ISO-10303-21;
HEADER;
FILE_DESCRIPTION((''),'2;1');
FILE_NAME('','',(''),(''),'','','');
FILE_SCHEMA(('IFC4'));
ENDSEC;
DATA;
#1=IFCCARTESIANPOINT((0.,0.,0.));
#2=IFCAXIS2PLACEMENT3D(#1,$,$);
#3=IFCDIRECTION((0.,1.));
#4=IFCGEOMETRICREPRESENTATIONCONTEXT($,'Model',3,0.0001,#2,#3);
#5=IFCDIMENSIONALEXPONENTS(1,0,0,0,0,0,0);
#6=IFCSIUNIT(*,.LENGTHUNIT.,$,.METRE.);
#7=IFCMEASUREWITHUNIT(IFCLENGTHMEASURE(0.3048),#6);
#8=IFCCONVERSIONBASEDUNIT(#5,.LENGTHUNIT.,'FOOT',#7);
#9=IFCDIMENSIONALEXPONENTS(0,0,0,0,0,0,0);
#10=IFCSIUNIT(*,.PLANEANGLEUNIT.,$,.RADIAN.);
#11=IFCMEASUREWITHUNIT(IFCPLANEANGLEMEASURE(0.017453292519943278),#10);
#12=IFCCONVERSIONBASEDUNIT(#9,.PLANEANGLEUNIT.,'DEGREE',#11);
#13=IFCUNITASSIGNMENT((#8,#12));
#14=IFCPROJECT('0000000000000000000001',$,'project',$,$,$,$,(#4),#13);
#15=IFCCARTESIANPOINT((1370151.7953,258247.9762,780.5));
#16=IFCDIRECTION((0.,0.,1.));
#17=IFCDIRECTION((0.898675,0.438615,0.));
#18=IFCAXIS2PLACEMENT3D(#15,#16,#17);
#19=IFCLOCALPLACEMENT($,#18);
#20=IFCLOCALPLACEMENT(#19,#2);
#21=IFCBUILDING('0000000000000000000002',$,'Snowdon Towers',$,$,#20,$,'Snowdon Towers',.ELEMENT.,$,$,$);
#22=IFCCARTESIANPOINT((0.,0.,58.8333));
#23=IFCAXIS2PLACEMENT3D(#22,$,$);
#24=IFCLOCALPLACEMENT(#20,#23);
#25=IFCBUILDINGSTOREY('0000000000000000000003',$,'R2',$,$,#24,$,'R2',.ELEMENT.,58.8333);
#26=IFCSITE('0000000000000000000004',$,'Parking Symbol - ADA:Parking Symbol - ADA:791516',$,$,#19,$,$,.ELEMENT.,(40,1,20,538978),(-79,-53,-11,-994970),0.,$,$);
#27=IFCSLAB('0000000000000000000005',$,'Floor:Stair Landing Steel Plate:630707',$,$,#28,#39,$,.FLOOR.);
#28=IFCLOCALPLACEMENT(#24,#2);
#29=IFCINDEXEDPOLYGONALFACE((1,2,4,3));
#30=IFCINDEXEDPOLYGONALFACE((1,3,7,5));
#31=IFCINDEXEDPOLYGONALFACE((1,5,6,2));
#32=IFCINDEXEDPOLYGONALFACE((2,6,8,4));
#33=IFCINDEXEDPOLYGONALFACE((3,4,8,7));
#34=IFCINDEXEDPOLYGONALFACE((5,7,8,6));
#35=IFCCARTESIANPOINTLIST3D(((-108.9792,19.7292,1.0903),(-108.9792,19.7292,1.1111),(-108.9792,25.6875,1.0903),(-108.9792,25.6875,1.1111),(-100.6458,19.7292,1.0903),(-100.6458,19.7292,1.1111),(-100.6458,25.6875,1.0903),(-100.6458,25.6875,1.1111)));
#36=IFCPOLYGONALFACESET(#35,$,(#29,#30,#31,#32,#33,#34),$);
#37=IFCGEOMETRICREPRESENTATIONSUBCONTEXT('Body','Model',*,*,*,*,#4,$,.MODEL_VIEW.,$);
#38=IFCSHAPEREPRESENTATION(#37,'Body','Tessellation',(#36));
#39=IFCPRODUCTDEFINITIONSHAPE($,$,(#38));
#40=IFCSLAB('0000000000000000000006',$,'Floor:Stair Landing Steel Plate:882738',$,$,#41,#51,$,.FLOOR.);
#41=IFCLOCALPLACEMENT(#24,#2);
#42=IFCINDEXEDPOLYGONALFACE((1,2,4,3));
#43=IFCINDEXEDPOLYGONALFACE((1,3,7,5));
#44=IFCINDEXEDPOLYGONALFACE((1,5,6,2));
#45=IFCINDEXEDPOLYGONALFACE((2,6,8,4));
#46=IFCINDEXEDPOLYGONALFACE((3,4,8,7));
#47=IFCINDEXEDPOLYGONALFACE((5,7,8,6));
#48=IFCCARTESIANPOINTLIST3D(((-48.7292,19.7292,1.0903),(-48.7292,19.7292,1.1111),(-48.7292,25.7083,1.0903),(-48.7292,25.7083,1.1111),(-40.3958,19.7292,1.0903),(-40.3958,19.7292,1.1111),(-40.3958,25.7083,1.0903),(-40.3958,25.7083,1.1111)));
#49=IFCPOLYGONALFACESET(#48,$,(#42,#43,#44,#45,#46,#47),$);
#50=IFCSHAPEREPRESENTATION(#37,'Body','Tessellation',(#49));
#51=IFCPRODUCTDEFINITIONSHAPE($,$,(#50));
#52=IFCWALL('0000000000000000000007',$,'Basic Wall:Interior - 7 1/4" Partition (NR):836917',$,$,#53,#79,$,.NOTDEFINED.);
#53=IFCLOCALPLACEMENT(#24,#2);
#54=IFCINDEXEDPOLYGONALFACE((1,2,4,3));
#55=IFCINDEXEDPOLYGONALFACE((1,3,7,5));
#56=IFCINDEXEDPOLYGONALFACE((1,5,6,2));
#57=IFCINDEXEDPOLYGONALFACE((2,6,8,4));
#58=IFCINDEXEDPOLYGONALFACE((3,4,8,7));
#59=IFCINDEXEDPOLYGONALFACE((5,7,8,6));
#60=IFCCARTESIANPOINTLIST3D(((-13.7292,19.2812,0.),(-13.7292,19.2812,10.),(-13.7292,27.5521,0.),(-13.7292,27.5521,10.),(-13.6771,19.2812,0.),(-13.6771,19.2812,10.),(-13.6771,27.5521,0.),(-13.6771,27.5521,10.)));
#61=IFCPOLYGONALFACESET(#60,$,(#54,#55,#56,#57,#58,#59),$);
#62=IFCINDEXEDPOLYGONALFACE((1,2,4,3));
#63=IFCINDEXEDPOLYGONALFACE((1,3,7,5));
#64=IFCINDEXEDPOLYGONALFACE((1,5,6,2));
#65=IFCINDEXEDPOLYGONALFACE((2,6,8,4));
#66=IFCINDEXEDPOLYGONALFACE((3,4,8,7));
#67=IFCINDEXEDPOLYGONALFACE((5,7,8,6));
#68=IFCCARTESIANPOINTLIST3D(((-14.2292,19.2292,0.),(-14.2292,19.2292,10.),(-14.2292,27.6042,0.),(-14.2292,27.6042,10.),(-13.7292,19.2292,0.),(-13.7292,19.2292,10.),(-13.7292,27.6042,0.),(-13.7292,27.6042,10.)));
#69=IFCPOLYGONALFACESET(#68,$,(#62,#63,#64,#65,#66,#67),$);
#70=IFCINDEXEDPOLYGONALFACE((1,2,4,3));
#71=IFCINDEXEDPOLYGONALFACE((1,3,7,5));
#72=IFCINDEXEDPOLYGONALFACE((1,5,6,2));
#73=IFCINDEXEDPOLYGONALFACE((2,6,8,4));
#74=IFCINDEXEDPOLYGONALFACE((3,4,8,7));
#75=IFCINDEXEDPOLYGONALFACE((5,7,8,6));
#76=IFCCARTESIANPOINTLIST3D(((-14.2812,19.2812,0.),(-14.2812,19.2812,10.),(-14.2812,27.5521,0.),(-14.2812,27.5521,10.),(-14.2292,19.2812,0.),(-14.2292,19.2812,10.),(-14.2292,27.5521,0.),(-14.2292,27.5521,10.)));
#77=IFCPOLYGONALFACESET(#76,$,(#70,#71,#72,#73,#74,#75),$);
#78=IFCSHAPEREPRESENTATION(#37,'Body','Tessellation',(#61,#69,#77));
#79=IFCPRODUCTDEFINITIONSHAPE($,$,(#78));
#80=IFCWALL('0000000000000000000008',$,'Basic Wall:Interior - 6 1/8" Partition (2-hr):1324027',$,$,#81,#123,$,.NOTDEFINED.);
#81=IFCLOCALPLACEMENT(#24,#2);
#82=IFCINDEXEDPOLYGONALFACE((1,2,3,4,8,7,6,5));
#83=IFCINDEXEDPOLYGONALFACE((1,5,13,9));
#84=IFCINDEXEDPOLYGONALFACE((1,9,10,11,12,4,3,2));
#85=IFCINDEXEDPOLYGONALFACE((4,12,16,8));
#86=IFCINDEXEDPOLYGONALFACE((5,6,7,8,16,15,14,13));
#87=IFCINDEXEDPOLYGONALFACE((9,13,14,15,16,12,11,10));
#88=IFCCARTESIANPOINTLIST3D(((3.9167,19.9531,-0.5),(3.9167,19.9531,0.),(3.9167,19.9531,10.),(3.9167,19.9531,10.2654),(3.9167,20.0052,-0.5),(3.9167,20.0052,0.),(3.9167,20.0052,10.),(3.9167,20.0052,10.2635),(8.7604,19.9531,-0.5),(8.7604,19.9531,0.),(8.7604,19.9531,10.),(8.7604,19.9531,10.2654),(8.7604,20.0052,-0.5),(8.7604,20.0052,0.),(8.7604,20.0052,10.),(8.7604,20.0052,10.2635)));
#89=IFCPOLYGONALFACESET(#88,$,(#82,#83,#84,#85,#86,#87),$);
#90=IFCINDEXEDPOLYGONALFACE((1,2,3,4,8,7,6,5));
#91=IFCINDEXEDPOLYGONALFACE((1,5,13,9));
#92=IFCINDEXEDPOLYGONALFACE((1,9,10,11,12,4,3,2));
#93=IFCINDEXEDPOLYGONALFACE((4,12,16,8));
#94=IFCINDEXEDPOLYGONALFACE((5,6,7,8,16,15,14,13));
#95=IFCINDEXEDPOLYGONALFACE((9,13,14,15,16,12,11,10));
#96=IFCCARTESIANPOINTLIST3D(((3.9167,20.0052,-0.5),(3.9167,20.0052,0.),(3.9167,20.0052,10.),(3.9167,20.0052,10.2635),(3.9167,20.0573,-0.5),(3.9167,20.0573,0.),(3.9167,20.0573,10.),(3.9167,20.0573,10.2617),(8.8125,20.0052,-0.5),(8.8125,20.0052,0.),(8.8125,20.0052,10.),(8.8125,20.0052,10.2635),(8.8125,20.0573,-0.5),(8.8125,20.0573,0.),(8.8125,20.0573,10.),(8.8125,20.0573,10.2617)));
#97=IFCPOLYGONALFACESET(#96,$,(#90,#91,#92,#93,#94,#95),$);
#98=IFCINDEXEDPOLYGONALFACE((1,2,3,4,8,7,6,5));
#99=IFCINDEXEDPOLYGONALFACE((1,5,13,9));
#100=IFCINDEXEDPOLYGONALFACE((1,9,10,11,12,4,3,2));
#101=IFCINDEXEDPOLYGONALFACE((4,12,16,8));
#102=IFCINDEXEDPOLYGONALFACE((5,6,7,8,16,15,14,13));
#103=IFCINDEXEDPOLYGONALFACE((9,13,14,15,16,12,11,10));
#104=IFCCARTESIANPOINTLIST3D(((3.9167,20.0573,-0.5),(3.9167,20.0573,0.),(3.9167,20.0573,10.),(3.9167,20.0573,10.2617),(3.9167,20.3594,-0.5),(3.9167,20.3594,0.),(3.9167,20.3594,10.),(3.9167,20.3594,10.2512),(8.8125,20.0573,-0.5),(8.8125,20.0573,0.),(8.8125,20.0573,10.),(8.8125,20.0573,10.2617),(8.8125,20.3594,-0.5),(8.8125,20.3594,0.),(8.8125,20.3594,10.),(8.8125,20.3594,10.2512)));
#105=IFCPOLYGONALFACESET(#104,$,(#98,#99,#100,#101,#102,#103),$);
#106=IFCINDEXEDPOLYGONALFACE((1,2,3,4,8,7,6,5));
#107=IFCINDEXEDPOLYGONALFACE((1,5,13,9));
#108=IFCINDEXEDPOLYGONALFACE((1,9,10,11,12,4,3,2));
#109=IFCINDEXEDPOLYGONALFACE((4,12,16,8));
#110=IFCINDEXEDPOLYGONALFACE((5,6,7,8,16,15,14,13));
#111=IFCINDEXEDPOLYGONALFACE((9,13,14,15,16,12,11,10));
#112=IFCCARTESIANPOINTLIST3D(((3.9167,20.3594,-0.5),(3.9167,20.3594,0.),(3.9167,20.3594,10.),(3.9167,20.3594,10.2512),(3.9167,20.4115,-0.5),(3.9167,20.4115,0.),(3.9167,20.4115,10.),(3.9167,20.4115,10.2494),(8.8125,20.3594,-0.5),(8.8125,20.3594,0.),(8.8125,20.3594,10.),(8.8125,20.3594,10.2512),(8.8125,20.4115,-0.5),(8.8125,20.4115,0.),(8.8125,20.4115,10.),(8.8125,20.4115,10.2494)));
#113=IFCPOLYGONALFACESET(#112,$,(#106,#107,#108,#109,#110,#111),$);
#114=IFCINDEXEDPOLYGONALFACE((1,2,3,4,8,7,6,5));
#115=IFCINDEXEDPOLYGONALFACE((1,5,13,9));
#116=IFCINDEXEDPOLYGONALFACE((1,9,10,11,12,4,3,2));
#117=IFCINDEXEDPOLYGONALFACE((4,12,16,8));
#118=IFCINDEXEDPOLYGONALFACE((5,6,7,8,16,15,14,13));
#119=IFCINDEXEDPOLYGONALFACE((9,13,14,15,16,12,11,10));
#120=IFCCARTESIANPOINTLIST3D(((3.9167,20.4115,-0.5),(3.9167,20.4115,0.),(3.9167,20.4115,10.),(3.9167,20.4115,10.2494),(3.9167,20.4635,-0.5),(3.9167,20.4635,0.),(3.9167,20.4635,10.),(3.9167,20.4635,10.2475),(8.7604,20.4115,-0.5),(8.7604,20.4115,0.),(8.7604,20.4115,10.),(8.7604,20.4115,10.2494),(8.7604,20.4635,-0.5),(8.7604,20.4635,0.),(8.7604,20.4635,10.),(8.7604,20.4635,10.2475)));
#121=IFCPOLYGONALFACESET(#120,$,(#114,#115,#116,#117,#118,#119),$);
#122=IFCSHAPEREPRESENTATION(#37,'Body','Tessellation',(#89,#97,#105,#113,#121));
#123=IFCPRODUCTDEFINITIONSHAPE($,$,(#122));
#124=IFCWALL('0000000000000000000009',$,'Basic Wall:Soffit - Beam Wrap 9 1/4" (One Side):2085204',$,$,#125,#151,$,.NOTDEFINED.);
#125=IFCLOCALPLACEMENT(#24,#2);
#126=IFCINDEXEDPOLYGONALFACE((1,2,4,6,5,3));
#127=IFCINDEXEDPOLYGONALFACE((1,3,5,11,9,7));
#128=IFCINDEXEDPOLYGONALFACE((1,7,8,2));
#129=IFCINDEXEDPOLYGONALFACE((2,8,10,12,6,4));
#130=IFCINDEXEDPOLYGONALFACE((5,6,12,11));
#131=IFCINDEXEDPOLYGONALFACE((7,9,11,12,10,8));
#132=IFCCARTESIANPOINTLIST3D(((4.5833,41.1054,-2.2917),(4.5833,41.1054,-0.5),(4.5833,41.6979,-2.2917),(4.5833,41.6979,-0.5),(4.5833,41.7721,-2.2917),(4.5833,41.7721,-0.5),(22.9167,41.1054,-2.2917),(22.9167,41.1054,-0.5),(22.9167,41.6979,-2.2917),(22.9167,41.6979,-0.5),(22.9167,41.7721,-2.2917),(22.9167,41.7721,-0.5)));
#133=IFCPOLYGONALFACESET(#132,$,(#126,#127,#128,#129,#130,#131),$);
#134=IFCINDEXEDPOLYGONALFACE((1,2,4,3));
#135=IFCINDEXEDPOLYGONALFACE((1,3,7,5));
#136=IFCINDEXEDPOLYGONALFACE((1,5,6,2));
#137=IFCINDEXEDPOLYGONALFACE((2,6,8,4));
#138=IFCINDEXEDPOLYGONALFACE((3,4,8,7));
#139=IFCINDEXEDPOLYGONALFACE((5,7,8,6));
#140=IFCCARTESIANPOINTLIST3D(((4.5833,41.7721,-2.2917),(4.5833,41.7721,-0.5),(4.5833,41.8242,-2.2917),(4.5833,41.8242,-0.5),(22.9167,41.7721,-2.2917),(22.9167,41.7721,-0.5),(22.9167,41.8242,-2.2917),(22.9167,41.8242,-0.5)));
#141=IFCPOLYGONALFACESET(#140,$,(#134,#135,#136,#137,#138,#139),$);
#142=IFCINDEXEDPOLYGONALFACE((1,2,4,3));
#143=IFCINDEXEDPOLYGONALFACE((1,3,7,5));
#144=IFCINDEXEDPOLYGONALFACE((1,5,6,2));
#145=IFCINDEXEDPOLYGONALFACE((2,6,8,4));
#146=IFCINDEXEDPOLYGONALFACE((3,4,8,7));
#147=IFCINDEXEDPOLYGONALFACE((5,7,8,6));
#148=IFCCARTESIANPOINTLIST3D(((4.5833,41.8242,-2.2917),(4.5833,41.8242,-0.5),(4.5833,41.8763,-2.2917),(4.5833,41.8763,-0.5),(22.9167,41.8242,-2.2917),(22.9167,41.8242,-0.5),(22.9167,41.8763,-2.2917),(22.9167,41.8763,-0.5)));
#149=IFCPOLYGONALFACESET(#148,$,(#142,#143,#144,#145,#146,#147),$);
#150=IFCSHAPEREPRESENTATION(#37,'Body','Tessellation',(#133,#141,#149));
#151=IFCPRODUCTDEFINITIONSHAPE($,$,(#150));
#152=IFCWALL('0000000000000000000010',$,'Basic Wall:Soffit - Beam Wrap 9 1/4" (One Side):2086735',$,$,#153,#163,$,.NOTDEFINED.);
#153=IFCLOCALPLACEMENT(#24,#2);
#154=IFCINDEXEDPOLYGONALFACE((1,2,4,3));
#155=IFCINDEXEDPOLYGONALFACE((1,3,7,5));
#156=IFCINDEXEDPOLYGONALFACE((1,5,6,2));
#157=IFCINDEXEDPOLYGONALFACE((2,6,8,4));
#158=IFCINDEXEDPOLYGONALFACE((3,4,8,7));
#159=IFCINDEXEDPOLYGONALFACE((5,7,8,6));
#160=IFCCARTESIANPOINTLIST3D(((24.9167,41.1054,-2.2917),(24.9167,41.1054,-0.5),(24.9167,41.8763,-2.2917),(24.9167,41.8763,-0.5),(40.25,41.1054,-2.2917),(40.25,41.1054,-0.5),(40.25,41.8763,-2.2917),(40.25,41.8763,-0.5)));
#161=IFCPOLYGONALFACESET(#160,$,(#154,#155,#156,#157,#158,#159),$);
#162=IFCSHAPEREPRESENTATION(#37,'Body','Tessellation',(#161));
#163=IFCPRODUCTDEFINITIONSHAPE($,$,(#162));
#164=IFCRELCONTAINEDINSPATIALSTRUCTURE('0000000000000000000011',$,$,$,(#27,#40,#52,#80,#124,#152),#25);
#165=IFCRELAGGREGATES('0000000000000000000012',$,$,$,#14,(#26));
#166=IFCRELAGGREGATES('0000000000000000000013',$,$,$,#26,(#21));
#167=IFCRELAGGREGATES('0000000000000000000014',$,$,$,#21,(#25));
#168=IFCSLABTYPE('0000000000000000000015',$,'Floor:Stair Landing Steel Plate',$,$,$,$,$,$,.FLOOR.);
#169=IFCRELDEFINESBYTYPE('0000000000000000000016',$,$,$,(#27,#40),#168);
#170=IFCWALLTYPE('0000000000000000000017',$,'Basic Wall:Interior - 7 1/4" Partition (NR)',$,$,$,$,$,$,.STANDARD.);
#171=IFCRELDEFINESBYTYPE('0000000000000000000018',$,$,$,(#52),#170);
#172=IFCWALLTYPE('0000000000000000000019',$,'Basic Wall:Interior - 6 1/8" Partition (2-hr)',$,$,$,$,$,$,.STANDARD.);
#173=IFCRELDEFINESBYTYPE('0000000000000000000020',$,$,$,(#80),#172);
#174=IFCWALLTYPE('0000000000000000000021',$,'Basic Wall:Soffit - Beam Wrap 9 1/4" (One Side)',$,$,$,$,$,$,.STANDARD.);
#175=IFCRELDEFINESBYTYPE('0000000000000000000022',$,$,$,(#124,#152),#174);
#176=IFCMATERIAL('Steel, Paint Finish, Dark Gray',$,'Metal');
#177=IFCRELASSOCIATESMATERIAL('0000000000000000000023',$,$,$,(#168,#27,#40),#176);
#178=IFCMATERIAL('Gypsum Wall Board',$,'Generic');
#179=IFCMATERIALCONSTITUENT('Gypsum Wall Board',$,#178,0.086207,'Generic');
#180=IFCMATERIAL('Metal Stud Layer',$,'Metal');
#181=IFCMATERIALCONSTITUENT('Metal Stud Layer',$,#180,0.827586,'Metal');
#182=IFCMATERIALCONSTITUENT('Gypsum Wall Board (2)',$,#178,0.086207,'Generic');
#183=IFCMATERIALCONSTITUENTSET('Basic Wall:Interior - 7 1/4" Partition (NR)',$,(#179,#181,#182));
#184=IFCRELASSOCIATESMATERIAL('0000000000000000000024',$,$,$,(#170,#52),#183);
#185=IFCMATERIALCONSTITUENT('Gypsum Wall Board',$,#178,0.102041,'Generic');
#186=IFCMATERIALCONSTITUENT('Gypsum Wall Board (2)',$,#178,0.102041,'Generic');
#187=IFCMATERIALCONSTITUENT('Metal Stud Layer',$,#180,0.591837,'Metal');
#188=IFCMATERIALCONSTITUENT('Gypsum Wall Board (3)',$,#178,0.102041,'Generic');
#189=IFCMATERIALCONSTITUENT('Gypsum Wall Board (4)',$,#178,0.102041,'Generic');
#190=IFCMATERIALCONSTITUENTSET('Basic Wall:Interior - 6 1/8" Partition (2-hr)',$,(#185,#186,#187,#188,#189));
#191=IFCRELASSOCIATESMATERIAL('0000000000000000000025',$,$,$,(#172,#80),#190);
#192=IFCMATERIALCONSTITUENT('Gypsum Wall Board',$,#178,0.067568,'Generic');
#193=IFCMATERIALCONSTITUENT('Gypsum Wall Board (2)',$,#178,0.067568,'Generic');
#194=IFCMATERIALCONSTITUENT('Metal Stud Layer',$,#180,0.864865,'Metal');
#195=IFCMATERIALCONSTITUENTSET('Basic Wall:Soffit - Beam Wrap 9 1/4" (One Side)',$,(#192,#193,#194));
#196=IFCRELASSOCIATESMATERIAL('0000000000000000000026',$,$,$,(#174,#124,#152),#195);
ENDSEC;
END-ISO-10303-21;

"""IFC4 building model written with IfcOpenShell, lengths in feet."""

from ifc_helpers import new_model, entity, si_unit, converted_unit, direction, frame, origin, place, context, subcontext, project, spatial, indexed_curve, outline, extrude, material, constituent, constituent_set, type_object, element, save


model = new_model("IFC4")

# Units and contexts
model_context = context("Model", 3, precision=0.0001, world=origin(), true_north=direction((0.0, 1.0)))
body_context = subcontext(model_context, "Body", "Model", "MODEL_VIEW")
ifc_project = project(units=[converted_unit("LENGTHUNIT", "FOOT", entity("IfcLengthMeasure", 0.3048), si_unit("LENGTHUNIT", "METRE"), dimensions=[1, 0, 0, 0, 0, 0, 0]), converted_unit("PLANEANGLEUNIT", "DEGREE", entity("IfcPlaneAngleMeasure", 0.017453292519943278), si_unit("PLANEANGLEUNIT", "RADIAN"), dimensions=[0, 0, 0, 0, 0, 0, 0])], contexts=[model_context])

# Site, building, storey
site_placement = place(None, frame((1370151.7953, 258247.9762, 780.5), z_axis=(0.0, 0.0, 1.0), x_axis=(0.898675, 0.438615, 0.0)))
site = spatial("IfcSite", under=ifc_project, at=site_placement, Name="Parking Symbol - ADA:Parking Symbol - ADA:791516", CompositionType="ELEMENT", RefLatitude=(40, 1, 20, 538978), RefLongitude=(-79, -53, -11, -994970), RefElevation=0.0)
building_placement = place(site_placement, origin())
building = spatial("IfcBuilding", under=site, at=building_placement, Name="Snowdon Towers", LongName="Snowdon Towers", CompositionType="ELEMENT")
storey_placement = place(building_placement, frame((0.0, 0.0, 58.8333)))
storey = spatial("IfcBuildingStorey", under=building, at=storey_placement, Name="R2", LongName="R2", CompositionType="ELEMENT", Elevation=58.8333)

# Slabs
ifc_material_1 = material(Name="Steel, Paint Finish, Dark Gray", Category="Metal")
slab_type_1 = type_object("IfcSlabType", Name="Floor:Stair Landing Steel Plate", PredefinedType="FLOOR", material=ifc_material_1)
slab_1_placement = place(storey_placement, origin())
element("IfcSlab", 1, at=slab_1_placement, inside=storey, type_object=slab_type_1, material=ifc_material_1, Name="Floor:Stair Landing Steel Plate:630707", PredefinedType="FLOOR", context=body_context, shape_type="SweptSolid", body=[
    extrude(outline(indexed_curve([(-2.9792, -4.1667), (2.9792, -4.1667), (2.9792, 4.1667), (-2.9792, 4.1667), (-2.9792, -4.1667)], self_intersect=False)), frame((-104.8125, 22.7083, 1.1111), z_axis=(0.0, 0.0, -1.0), x_axis=(0.0, 1.0, 0.0)), (0.0, 0.0, 1.0), 0.0208),
])
slab_2_placement = place(storey_placement, origin())
element("IfcSlab", 2, at=slab_2_placement, inside=storey, type_object=slab_type_1, material=ifc_material_1, Name="Floor:Stair Landing Steel Plate:882738", PredefinedType="FLOOR", context=body_context, shape_type="SweptSolid", body=[
    extrude(outline(indexed_curve([(-2.9896, -4.1667), (2.9896, -4.1667), (2.9896, 4.1667), (-2.9896, 4.1667), (-2.9896, -4.1667)], self_intersect=False)), frame((-44.5625, 22.7188, 1.1111), z_axis=(0.0, 0.0, -1.0), x_axis=(0.0, 1.0, 0.0)), (0.0, 0.0, 1.0), 0.0208),
])

# Walls
ifc_material_2 = material(Name="Gypsum Wall Board", Category="Generic")
ifc_constituent_1 = constituent(ifc_material_2, Name="Gypsum Wall Board", Category="Generic", fraction=0.086207)
ifc_material_3 = material(Name="Metal Stud Layer", Category="Metal")
ifc_constituent_2 = constituent(ifc_material_3, Name="Metal Stud Layer", Category="Metal", fraction=0.827586)
ifc_constituent_3 = constituent(ifc_material_2, Name="Gypsum Wall Board (2)", Category="Generic", fraction=0.086207)
ifc_constituent_set_1 = constituent_set(constituents=[ifc_constituent_1, ifc_constituent_2, ifc_constituent_3], Name="Basic Wall:Interior - 7 1/4\" Partition (NR)")
wall_type_1 = type_object("IfcWallType", Name="Basic Wall:Interior - 7 1/4\" Partition (NR)", PredefinedType="STANDARD", material=ifc_constituent_set_1)
wall_1_placement = place(storey_placement, frame((-13.9792, 19.2812, 0.0), z_axis=(0.0, 0.0, 1.0), x_axis=(0.0, 1.0, 0.0)))
element("IfcWall", 3, at=wall_1_placement, inside=storey, type_object=wall_type_1, material=ifc_constituent_set_1, Name="Basic Wall:Interior - 7 1/4\" Partition (NR):836917", PredefinedType="NOTDEFINED", context=body_context, shape_type="SweptSolid", body=[
    extrude(outline(indexed_curve([(-0.026, -4.1354), (0.026, -4.1354), (0.026, 4.1354), (-0.026, 4.1354), (-0.026, -4.1354)], self_intersect=False)), frame((4.1354, -0.276, 0.0), z_axis=(0.0, 0.0, 1.0), x_axis=(0.0, 1.0, 0.0)), (0.0, 0.0, 1.0), 10.0),
    extrude(outline(indexed_curve([(-4.1875, -0.25), (4.1875, -0.25), (4.1875, 0.25), (-4.1875, 0.25), (-4.1875, -0.25)], self_intersect=False)), frame((4.1354, 0.0, 0.0)), (0.0, 0.0, 1.0), 10.0),
    extrude(outline(indexed_curve([(-0.026, -4.1354), (0.026, -4.1354), (0.026, 4.1354), (-0.026, 4.1354), (-0.026, -4.1354)], self_intersect=False)), frame((4.1354, 0.276, 0.0), z_axis=(0.0, 0.0, 1.0), x_axis=(0.0, -1.0, 0.0)), (0.0, 0.0, 1.0), 10.0),
])
ifc_constituent_4 = constituent(ifc_material_2, Name="Gypsum Wall Board", Category="Generic", fraction=0.102041)
ifc_constituent_5 = constituent(ifc_material_2, Name="Gypsum Wall Board (2)", Category="Generic", fraction=0.102041)
ifc_constituent_6 = constituent(ifc_material_3, Name="Metal Stud Layer", Category="Metal", fraction=0.591837)
ifc_constituent_7 = constituent(ifc_material_2, Name="Gypsum Wall Board (3)", Category="Generic", fraction=0.102041)
ifc_constituent_8 = constituent(ifc_material_2, Name="Gypsum Wall Board (4)", Category="Generic", fraction=0.102041)
ifc_constituent_set_2 = constituent_set(constituents=[ifc_constituent_4, ifc_constituent_5, ifc_constituent_6, ifc_constituent_7, ifc_constituent_8], Name="Basic Wall:Interior - 6 1/8\" Partition (2-hr)")
wall_type_2 = type_object("IfcWallType", Name="Basic Wall:Interior - 6 1/8\" Partition (2-hr)", PredefinedType="STANDARD", material=ifc_constituent_set_2)
wall_2_placement = place(storey_placement, frame((3.9167, 20.2083, -0.5)))
element("IfcWall", 4, at=wall_2_placement, inside=storey, type_object=wall_type_2, material=ifc_constituent_set_2, Name="Basic Wall:Interior - 6 1/8\" Partition (2-hr):1324027", PredefinedType="NOTDEFINED", context=body_context, shape_type="SweptSolid", body=[
    extrude(outline(indexed_curve([(-5.4411, -0.026), (-4.9411, -0.026), (5.0589, -0.026), (5.3224, -0.026), (5.3242, 0.026), (5.0589, 0.026), (-4.9411, 0.026), (-5.4411, 0.026), (-5.4411, -0.026)], self_intersect=False)), frame((0.0, -0.2292, 5.4411), z_axis=(1.0, 0.0, 0.0), x_axis=(0.0, 0.0, 1.0)), (0.0, 0.0, 1.0), 4.8437),
    extrude(outline(indexed_curve([(-0.026, -5.4407), (0.026, -5.4407), (0.026, -4.9407), (0.026, 5.0593), (0.026, 5.3211), (-0.026, 5.3229), (-0.026, 5.0593), (-0.026, -4.9407), (-0.026, -5.4407)], self_intersect=False)), frame((0.0, -0.1771, 5.4407), z_axis=(1.0, 0.0, 0.0), x_axis=(0.0, 1.0, 0.0)), (0.0, 0.0, 1.0), 4.8958),
    extrude(outline(indexed_curve([(-0.151, -5.4391), (0.151, -5.4391), (0.151, -4.9391), (0.151, 5.0609), (0.151, 5.3121), (-0.151, 5.3226), (-0.151, 5.0609), (-0.151, -4.9391), (-0.151, -5.4391)], self_intersect=False)), frame((0.0, 0.0, 5.4391), z_axis=(1.0, 0.0, 0.0), x_axis=(0.0, 1.0, 0.0)), (0.0, 0.0, 1.0), 4.8958),
    extrude(outline(indexed_curve([(-0.026, -5.4376), (0.026, -5.4376), (0.026, -4.9376), (0.026, 5.0624), (0.026, 5.3118), (-0.026, 5.3136), (-0.026, 5.0624), (-0.026, -4.9376), (-0.026, -5.4376)], self_intersect=False)), frame((0.0, 0.1771, 5.4376), z_axis=(1.0, 0.0, 0.0), x_axis=(0.0, 1.0, 0.0)), (0.0, 0.0, 1.0), 4.8958),
    extrude(outline(indexed_curve([(-0.026, -5.4371), (0.026, -5.4371), (0.026, -4.9371), (0.026, 5.0629), (0.026, 5.3104), (-0.026, 5.3122), (-0.026, 5.0629), (-0.026, -4.9371), (-0.026, -5.4371)], self_intersect=False)), frame((0.0, 0.2292, 5.4371), z_axis=(1.0, 0.0, 0.0), x_axis=(0.0, 1.0, 0.0)), (0.0, 0.0, 1.0), 4.8437),
])

# Walls
ifc_constituent_9 = constituent(ifc_material_2, Name="Gypsum Wall Board", Category="Generic", fraction=0.067568)
ifc_constituent_10 = constituent(ifc_material_2, Name="Gypsum Wall Board (2)", Category="Generic", fraction=0.067568)
ifc_constituent_11 = constituent(ifc_material_3, Name="Metal Stud Layer", Category="Metal", fraction=0.864865)
ifc_constituent_set_3 = constituent_set(constituents=[ifc_constituent_9, ifc_constituent_10, ifc_constituent_11], Name="Basic Wall:Soffit - Beam Wrap 9 1/4\" (One Side)")
wall_type_3 = type_object("IfcWallType", Name="Basic Wall:Soffit - Beam Wrap 9 1/4\" (One Side)", PredefinedType="STANDARD", material=ifc_constituent_set_3)
wall_3_placement = place(storey_placement, frame((4.5833, 41.4908, -2.2917)))
element("IfcWall", 5, at=wall_3_placement, inside=storey, type_object=wall_type_3, material=ifc_constituent_set_3, Name="Basic Wall:Soffit - Beam Wrap 9 1/4\" (One Side):2085204", PredefinedType="NOTDEFINED", context=body_context, shape_type="SweptSolid", body=[
    extrude(outline(indexed_curve([(-0.4197, -9.1667), (0.1728, -9.1667), (0.2469, -9.1667), (0.2469, 9.1667), (0.1728, 9.1667), (-0.4197, 9.1667), (-0.4197, -9.1667)], self_intersect=False)), frame((9.1667, 0.0343, 0.0), z_axis=(0.0, 0.0, 1.0), x_axis=(0.0, 1.0, 0.0)), (0.0, 0.0, 1.0), 1.7917),
    extrude(outline(indexed_curve([(-9.1667, -0.026), (9.1667, -0.026), (9.1667, 0.026), (-9.1667, 0.026), (-9.1667, -0.026)], self_intersect=False)), frame((9.1667, 0.3073, 0.0)), (0.0, 0.0, 1.0), 1.7917),
    extrude(outline(indexed_curve([(-0.026, -9.1667), (0.026, -9.1667), (0.026, 9.1667), (-0.026, 9.1667), (-0.026, -9.1667)], self_intersect=False)), frame((9.1667, 0.3594, 0.0), z_axis=(0.0, 0.0, 1.0), x_axis=(0.0, -1.0, 0.0)), (0.0, 0.0, 1.0), 1.7917),
])
wall_4_placement = place(storey_placement, frame((24.9167, 41.4908, -2.2917)))
element("IfcWall", 6, at=wall_4_placement, inside=storey, type_object=wall_type_3, material=ifc_constituent_set_3, Name="Basic Wall:Soffit - Beam Wrap 9 1/4\" (One Side):2086735", PredefinedType="NOTDEFINED", context=body_context, shape_type="SweptSolid", body=[
    extrude(outline(indexed_curve([(15.3333, 0.3854), (0.0, 0.3854), (0.0, -0.3854), (15.3333, -0.3854), (15.3333, 0.3854)], self_intersect=False)), origin(), (0.0, 0.0, 1.0), 1.7917),
])

save(model, "model.ifc")
